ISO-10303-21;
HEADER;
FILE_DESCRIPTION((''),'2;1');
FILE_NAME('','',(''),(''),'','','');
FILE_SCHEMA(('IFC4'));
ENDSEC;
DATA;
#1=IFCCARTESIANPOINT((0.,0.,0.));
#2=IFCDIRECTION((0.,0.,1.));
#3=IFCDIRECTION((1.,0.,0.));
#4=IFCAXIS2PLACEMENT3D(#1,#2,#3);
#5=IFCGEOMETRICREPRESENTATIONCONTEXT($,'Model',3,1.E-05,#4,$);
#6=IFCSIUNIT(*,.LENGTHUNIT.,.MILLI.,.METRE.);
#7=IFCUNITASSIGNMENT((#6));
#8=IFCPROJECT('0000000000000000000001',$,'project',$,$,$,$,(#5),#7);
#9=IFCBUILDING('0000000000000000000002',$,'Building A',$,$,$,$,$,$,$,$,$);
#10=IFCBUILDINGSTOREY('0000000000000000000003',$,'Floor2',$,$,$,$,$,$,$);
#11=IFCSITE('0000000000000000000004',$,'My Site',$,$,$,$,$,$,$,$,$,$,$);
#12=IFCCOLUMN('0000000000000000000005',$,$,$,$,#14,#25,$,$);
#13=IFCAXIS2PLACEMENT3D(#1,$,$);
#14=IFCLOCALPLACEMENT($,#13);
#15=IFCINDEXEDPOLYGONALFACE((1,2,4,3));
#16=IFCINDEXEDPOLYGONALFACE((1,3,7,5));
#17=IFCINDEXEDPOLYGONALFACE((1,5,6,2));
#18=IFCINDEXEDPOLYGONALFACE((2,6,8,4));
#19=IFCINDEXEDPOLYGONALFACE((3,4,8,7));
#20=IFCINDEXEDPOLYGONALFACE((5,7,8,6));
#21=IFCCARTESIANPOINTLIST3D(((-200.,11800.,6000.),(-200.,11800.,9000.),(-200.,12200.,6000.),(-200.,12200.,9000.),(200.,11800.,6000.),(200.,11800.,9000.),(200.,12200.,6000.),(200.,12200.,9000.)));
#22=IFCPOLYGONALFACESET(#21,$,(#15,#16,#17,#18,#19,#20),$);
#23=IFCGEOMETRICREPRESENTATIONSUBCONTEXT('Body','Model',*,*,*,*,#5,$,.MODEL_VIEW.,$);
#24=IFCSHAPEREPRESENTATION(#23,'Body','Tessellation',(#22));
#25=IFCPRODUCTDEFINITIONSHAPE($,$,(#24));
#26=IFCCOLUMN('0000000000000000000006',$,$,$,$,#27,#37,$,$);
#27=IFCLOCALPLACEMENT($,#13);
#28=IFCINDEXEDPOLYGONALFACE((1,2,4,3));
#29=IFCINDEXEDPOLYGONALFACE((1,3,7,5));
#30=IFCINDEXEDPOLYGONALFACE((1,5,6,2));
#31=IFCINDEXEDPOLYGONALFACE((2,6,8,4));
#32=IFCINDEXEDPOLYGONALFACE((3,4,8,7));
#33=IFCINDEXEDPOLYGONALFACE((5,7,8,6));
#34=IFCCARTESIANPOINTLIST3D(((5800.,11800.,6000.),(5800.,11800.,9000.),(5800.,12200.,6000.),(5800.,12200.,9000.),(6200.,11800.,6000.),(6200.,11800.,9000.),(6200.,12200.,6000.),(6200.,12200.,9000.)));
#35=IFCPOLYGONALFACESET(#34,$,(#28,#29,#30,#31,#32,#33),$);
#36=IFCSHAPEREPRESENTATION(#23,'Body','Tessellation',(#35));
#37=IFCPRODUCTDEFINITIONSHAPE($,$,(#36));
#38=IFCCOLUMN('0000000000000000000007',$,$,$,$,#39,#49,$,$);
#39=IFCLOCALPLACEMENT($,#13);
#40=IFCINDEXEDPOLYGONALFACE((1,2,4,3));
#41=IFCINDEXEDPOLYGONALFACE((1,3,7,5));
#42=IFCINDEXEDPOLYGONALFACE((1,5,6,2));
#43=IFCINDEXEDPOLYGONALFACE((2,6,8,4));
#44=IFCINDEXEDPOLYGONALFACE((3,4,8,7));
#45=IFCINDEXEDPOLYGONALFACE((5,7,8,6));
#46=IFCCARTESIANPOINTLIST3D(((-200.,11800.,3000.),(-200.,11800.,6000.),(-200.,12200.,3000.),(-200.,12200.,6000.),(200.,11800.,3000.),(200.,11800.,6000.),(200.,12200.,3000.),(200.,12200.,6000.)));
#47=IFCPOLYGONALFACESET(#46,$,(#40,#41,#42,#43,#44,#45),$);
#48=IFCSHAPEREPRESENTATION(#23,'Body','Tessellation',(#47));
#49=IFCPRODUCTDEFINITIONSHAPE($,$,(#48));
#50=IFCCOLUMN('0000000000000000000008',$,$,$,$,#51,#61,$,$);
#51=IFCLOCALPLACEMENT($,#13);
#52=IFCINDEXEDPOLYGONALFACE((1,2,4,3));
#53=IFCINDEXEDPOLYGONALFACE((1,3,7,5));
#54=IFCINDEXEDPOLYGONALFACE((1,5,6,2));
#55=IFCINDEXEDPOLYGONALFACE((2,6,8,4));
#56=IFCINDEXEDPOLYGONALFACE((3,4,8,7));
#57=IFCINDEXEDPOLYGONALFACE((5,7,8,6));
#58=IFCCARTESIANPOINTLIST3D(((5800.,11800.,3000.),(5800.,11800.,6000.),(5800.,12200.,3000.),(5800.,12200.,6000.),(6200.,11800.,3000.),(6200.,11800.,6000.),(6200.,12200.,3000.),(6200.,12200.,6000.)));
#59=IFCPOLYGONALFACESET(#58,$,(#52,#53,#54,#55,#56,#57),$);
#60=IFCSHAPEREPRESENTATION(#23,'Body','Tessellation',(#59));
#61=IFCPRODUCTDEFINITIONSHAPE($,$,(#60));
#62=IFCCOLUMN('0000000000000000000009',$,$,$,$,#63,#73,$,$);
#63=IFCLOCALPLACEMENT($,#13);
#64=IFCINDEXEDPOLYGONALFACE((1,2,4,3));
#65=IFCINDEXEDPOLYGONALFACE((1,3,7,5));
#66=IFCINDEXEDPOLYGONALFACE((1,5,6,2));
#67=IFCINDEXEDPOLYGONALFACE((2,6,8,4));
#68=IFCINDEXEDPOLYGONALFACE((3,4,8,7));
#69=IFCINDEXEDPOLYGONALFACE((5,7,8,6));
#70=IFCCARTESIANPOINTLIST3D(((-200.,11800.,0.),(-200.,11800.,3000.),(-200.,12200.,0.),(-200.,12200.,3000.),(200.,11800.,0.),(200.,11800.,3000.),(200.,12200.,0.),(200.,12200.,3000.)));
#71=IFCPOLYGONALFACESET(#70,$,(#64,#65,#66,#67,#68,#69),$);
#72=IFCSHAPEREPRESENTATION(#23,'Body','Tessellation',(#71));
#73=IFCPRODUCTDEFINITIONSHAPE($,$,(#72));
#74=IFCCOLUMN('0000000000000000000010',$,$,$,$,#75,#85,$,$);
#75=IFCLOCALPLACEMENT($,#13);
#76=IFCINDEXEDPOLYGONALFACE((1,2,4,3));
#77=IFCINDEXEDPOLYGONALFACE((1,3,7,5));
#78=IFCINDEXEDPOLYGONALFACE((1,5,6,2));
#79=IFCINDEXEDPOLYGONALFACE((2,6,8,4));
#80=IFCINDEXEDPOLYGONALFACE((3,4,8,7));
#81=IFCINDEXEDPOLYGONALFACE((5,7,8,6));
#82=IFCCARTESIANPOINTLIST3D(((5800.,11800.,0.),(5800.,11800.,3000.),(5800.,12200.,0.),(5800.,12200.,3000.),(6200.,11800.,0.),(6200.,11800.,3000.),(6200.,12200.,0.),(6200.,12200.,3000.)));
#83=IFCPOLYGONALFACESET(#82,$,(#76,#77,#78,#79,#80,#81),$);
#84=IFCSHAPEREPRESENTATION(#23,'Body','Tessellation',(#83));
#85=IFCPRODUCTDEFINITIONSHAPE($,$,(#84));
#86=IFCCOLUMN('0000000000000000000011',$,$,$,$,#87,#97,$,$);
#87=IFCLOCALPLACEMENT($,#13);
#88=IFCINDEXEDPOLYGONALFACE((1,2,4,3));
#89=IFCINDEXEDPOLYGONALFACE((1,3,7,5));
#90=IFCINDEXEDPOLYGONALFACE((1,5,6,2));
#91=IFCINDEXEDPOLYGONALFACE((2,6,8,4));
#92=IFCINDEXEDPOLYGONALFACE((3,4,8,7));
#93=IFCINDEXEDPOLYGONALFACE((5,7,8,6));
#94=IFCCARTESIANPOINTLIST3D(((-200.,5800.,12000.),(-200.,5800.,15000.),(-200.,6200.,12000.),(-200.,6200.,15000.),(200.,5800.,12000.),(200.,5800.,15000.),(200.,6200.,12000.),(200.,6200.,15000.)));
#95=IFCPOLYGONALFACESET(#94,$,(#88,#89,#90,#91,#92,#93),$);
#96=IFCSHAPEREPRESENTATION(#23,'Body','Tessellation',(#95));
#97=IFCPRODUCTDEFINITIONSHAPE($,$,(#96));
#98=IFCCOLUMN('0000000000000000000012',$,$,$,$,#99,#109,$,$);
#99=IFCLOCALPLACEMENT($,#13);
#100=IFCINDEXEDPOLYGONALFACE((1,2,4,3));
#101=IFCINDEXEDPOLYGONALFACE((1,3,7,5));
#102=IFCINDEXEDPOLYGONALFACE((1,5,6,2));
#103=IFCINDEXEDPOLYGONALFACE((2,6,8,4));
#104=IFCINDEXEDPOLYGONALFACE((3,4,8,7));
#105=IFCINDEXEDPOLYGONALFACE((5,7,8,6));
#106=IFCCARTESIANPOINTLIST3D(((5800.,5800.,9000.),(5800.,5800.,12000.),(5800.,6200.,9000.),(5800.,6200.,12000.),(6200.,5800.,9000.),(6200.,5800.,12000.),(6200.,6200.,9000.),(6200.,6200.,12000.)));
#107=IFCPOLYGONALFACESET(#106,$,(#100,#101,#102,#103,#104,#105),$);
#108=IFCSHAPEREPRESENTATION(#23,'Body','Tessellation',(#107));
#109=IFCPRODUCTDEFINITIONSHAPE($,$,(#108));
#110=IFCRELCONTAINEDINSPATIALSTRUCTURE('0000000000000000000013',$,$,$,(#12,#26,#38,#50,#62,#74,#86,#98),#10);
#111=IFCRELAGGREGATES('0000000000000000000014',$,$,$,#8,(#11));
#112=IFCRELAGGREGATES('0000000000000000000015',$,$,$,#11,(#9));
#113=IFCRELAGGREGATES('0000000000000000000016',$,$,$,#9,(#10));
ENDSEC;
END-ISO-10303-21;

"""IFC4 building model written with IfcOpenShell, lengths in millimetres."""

from ifc_helpers import new_model, si_unit, frame, origin_with_axes, place, context, subcontext, project, spatial, line, indexed_curve, outline, extrude, element, save


model = new_model("IFC4")

# Units and contexts
model_context = context("Model", 3, precision=1e-05, world=origin_with_axes())
body_context = subcontext(model_context, "Body", "Model", "MODEL_VIEW")
ifc_project = project(units=[si_unit("LENGTHUNIT", "METRE", prefix="MILLI")], contexts=[model_context])

# Site, building, storey
site = spatial("IfcSite", under=ifc_project, Name="My Site")
building = spatial("IfcBuilding", under=site, Name="Building A")
storey = spatial("IfcBuildingStorey", under=building, Name="Floor2")

# Columns
for number, where, z_axis, x_axis in (
    (1, (0.0, 12000.0, 6000.0), (0.0, 0.0, 1.0), (1.0, 0.0, 0.0)),
    (2, (6000.0, 12000.0, 6000.0), (0.0, 0.0, 1.0), (1.0, 0.0, 0.0)),
    (3, (0.0, 12000.0, 3000.0), (0.0, 0.0, 1.0), (1.0, 0.0, 0.0)),
    (4, (6000.0, 12000.0, 3000.0), (0.0, 0.0, 1.0), (1.0, 0.0, 0.0)),
    (5, (0.0, 12000.0, 0.0), (0.0, 0.0, 1.0), (1.0, 0.0, 0.0)),
    (6, (6000.0, 12000.0, 0.0), (0.0, 0.0, 1.0), (1.0, 0.0, 0.0)),
    (7, (0.0, 6000.0, 12000.0), (0.0, 0.0, 1.0), (1.0, 0.0, 0.0)),
    (8, (6000.0, 6000.0, 9000.0), (0.0, 0.0, 1.0), (1.0, 0.0, 0.0)),
):
    element("IfcColumn", number, at=place(None, frame(where, z_axis=z_axis, x_axis=x_axis)), inside=storey, context=body_context, shape_type="SweptSolid", body=[
        extrude(outline(indexed_curve([(-200.0, -200.0), (200.0, -200.0), (200.0, 200.0), (-200.0, 200.0)], segments=[line(1, 2, 3, 4, 1)])), origin_with_axes(), (0.0, 0.0, 1.0), 3000.0),
    ])

save(model, "model.ifc")
